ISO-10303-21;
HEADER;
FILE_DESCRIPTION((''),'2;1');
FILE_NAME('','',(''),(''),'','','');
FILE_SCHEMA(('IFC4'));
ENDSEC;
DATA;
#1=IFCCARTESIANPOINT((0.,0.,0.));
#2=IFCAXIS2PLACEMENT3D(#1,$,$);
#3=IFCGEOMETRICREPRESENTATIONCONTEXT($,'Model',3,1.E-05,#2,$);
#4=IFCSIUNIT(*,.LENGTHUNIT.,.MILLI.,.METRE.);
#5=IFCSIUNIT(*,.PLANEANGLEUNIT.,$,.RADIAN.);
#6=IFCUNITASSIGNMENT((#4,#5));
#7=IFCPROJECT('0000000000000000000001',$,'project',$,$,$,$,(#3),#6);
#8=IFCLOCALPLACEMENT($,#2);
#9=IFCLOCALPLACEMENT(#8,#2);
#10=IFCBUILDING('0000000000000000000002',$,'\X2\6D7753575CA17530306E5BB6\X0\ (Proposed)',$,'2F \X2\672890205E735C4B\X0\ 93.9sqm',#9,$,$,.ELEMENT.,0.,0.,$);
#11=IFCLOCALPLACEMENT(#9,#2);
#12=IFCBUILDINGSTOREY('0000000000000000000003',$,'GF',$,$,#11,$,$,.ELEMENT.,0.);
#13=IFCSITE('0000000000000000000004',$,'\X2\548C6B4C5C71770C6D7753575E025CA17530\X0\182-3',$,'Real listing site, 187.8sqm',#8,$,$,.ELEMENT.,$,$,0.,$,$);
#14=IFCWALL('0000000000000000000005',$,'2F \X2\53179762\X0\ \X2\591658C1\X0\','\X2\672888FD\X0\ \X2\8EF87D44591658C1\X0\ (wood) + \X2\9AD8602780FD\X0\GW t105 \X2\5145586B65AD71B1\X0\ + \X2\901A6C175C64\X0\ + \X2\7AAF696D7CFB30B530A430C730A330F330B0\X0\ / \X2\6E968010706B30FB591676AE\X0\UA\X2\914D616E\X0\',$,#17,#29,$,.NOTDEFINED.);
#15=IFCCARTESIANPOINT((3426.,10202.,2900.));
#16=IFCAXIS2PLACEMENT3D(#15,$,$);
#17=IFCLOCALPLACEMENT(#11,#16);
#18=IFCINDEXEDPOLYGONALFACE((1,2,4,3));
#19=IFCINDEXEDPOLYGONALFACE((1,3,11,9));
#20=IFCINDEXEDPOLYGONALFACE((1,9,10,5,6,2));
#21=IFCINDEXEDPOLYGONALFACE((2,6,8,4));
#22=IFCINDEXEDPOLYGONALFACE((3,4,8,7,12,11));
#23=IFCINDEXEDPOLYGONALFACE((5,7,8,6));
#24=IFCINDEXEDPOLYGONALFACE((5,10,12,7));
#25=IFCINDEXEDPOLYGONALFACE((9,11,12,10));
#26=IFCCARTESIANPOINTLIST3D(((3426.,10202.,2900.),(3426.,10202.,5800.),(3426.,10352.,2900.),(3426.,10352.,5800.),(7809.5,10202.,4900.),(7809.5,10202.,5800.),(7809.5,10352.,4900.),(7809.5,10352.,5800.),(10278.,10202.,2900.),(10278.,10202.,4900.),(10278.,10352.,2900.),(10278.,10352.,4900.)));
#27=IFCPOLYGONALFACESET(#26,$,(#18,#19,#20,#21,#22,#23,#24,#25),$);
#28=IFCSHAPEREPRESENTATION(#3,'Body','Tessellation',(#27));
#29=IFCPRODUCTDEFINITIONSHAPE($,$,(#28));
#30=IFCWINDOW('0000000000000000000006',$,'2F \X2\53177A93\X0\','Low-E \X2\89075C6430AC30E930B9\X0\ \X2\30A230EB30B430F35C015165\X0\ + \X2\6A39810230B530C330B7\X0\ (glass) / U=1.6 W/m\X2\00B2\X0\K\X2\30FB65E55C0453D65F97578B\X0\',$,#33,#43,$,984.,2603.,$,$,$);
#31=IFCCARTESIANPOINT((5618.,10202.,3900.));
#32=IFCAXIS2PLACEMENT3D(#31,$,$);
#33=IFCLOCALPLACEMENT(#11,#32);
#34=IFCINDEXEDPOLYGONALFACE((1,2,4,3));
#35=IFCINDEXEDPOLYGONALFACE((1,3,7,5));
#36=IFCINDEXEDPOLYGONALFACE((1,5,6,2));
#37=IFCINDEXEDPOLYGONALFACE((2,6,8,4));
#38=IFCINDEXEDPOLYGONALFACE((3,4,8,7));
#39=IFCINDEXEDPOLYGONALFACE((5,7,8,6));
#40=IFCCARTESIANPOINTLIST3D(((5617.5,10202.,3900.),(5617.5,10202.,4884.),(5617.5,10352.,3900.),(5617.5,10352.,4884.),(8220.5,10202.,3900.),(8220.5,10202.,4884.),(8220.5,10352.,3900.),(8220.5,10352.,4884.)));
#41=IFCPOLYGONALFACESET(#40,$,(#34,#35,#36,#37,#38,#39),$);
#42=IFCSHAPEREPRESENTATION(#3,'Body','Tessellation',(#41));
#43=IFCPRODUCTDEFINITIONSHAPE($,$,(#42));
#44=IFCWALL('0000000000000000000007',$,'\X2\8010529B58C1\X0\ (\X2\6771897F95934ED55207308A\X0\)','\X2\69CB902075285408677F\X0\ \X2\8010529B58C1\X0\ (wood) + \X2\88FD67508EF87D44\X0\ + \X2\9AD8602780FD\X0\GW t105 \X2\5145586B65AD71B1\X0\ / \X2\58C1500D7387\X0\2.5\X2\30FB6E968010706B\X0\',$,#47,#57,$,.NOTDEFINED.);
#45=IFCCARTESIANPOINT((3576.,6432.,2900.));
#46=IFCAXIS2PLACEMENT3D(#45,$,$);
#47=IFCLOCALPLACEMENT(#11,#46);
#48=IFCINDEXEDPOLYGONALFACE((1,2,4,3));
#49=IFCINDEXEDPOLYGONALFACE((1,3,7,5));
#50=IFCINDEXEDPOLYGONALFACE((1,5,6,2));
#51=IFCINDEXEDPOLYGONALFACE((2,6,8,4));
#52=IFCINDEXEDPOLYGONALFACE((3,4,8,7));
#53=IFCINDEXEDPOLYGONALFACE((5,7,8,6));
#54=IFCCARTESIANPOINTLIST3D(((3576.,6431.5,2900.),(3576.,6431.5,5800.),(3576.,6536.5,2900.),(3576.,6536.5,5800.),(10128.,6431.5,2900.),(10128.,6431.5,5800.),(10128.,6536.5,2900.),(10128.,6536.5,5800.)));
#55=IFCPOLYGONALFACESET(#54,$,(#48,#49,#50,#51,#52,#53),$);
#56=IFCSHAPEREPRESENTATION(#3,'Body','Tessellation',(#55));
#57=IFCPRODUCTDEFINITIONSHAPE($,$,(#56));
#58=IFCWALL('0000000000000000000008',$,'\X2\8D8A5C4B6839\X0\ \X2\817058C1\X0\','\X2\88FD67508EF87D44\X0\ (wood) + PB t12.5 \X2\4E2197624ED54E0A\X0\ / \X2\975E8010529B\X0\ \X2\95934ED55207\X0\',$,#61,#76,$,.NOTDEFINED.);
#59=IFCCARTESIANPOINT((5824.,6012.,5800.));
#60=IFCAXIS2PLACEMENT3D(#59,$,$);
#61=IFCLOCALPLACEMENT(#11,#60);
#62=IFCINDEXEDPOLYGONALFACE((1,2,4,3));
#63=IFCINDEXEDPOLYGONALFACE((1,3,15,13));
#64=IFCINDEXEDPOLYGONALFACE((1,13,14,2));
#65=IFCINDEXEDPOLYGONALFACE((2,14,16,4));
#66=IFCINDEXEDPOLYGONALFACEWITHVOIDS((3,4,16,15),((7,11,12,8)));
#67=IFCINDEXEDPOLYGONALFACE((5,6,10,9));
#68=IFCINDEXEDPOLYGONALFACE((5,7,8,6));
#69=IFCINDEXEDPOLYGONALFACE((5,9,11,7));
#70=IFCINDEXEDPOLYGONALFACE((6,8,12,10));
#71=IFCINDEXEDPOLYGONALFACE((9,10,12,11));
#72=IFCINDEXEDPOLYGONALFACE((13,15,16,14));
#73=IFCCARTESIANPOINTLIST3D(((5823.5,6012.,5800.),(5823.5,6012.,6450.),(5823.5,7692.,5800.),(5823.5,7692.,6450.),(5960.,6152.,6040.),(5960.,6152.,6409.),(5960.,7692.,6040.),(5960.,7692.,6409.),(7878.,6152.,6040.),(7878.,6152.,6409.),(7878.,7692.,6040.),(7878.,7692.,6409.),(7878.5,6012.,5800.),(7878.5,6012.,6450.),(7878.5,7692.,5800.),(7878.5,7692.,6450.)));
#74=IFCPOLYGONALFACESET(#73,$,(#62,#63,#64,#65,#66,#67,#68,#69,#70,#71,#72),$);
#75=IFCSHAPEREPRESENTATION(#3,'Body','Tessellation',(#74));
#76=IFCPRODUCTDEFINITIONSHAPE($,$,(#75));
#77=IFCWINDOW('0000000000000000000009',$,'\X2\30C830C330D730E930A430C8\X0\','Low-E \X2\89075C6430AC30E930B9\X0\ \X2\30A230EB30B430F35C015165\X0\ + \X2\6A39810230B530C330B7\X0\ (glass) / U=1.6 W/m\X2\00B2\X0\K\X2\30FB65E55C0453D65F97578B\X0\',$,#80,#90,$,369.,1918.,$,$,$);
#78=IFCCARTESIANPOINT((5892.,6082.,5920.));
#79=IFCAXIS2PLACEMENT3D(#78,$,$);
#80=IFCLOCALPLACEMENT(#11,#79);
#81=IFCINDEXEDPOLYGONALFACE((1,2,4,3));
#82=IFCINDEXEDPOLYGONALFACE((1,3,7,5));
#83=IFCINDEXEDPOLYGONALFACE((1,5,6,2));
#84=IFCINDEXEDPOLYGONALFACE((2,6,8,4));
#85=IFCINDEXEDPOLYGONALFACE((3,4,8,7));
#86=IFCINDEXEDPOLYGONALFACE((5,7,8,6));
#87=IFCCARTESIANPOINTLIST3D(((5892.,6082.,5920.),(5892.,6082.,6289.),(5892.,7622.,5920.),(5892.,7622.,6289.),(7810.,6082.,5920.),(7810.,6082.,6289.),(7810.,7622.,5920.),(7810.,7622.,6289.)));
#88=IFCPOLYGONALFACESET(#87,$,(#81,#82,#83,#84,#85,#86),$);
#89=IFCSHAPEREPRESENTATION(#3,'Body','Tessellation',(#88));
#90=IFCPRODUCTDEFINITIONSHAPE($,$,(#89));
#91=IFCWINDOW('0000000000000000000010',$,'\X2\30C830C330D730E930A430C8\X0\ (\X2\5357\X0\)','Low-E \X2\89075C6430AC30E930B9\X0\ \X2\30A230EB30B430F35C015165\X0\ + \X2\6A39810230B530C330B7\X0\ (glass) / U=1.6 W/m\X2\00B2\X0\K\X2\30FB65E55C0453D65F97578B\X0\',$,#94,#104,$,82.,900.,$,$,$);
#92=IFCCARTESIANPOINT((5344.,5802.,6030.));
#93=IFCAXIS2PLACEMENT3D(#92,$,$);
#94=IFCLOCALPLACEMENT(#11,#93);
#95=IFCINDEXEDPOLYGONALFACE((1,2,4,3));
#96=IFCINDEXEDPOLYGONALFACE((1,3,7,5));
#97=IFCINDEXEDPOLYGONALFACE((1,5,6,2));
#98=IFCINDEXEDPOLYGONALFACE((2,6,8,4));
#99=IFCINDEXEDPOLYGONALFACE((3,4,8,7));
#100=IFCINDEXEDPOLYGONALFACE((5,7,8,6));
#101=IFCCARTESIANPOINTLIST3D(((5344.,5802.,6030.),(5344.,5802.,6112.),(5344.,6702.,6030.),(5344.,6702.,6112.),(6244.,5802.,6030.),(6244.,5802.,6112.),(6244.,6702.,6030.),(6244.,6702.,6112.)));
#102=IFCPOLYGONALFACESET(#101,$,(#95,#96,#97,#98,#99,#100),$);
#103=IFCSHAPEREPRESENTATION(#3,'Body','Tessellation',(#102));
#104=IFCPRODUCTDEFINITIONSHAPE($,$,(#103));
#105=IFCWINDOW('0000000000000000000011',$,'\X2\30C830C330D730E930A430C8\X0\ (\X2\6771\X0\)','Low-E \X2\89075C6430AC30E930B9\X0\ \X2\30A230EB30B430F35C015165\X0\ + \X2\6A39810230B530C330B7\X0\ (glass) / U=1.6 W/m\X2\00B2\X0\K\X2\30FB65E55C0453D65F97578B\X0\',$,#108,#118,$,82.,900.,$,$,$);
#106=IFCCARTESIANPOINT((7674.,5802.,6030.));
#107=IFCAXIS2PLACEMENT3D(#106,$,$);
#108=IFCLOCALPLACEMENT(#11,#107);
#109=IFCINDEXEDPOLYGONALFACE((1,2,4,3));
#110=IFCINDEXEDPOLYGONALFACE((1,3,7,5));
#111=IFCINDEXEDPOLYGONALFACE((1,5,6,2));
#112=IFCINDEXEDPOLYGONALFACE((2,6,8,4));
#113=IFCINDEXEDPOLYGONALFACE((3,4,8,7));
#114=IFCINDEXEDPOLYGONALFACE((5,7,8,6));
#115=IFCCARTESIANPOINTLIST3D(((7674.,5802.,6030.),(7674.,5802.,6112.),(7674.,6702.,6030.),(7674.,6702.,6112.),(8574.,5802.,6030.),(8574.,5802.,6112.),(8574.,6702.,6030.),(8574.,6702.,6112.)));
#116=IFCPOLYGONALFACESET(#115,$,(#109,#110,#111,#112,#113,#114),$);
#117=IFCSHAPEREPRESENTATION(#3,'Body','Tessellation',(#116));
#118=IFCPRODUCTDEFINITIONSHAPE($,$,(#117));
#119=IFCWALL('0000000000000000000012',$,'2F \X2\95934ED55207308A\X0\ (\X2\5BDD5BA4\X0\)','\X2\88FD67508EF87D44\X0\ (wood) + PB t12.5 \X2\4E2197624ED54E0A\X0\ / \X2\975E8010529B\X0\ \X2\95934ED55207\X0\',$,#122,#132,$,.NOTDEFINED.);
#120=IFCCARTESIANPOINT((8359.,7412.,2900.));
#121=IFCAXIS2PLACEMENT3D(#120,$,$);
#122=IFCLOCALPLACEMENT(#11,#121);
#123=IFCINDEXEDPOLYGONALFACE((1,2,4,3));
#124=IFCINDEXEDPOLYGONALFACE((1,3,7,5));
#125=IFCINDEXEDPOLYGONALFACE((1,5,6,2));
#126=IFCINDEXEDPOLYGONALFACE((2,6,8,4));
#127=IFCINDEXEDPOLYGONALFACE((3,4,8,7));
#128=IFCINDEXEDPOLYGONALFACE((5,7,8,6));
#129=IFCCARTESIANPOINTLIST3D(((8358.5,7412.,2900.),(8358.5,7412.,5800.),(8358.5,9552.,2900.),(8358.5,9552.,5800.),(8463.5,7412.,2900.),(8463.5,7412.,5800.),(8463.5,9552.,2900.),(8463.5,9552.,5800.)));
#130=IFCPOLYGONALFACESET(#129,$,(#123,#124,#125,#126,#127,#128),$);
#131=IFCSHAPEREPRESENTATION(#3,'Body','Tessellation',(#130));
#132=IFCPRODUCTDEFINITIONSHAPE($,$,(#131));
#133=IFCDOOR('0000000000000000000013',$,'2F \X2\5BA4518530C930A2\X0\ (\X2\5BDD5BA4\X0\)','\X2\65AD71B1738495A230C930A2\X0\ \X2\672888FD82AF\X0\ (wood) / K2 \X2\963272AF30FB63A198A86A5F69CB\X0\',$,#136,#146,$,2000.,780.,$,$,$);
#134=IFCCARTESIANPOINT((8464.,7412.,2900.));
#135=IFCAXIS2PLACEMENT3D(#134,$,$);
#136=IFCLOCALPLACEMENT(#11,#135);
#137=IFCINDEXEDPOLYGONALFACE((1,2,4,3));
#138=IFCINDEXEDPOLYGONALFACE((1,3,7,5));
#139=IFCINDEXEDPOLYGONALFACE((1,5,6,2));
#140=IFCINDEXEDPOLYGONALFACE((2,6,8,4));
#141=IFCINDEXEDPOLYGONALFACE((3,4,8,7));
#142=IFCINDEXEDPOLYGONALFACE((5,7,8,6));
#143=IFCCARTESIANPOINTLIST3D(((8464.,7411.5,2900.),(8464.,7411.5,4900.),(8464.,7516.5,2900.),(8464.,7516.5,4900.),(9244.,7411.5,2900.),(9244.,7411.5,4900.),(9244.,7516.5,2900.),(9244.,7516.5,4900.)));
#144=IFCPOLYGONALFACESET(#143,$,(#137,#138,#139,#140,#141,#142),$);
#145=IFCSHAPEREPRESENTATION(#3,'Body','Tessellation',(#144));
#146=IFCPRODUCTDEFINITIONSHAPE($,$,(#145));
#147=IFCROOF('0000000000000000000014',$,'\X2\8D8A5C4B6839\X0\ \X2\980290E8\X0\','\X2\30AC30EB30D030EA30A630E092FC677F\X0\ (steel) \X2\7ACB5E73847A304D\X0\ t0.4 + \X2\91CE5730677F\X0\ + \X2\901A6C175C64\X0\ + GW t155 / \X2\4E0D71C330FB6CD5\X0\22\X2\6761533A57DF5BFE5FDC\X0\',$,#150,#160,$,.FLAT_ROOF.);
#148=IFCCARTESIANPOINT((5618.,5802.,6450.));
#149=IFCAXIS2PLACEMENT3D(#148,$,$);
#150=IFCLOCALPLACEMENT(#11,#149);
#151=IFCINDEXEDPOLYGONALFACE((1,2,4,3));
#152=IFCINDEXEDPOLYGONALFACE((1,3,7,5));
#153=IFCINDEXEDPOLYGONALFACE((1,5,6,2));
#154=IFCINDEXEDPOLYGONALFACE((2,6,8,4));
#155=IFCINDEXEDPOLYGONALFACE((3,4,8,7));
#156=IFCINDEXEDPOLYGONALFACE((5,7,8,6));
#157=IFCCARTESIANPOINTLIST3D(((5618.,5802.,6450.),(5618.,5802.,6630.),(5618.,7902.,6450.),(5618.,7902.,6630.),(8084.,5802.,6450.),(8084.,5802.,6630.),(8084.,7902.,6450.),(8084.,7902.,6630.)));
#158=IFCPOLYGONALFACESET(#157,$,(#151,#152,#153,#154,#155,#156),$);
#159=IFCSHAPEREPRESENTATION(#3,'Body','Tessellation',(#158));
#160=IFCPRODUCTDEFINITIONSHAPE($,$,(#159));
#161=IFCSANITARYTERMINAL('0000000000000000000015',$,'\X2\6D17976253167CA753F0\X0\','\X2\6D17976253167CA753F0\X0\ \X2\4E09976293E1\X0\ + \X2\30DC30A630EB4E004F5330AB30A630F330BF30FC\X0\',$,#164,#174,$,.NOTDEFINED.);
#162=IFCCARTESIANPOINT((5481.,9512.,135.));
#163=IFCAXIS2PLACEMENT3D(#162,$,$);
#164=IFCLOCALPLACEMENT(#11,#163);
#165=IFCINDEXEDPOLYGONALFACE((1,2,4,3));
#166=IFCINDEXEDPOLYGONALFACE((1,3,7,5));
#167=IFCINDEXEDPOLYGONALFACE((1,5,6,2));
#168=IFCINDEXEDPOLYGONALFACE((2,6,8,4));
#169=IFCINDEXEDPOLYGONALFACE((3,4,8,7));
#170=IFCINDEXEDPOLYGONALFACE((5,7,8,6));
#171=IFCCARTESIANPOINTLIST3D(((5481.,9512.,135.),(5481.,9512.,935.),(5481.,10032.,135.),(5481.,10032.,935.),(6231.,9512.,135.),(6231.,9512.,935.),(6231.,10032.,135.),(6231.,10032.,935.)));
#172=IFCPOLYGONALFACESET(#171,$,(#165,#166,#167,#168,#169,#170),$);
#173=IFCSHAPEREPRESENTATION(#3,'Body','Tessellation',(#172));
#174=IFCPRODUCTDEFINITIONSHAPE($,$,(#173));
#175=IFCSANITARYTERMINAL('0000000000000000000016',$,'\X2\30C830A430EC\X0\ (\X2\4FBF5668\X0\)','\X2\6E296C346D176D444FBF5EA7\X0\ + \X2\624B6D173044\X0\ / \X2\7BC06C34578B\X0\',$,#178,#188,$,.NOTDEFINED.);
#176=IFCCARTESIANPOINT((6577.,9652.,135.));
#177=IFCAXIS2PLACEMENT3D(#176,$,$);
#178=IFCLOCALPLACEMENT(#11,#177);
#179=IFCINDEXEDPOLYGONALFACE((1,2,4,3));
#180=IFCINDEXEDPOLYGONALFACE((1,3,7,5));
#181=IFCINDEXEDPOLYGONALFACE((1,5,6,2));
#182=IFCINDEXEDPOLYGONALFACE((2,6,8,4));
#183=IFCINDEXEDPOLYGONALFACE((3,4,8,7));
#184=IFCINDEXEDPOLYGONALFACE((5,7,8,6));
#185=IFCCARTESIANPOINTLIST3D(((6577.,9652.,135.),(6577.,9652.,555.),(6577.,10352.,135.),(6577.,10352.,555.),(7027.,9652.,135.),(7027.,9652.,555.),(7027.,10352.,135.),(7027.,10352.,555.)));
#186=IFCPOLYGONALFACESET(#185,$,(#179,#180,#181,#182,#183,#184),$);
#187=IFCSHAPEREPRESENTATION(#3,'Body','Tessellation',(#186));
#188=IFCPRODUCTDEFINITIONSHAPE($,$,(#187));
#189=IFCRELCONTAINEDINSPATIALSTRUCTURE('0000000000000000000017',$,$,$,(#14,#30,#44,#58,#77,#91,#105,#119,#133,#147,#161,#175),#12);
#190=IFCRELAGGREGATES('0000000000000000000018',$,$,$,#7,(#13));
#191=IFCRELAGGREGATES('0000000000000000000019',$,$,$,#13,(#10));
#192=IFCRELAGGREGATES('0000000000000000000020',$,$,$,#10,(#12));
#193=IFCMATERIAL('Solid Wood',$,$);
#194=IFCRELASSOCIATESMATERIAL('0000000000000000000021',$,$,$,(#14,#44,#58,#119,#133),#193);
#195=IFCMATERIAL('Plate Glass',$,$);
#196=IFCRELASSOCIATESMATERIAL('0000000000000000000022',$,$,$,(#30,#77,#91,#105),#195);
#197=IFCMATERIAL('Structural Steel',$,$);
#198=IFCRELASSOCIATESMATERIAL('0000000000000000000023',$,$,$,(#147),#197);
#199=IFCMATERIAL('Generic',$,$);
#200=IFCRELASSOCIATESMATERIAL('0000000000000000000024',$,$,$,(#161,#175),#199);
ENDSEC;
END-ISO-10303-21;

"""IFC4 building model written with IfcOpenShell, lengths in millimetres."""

from ifc_helpers import new_model, si_unit, frame, frame_2d, origin, place, context, project, spatial, rectangle, extrude, material, element, fill, save


model = new_model("IFC4")

# Units and contexts
model_context = context("Model", 3, precision=1e-05, world=origin())
ifc_project = project(units=[si_unit("LENGTHUNIT", "METRE", prefix="MILLI"), si_unit("PLANEANGLEUNIT", "RADIAN")], contexts=[model_context])

# Site, building, storey
site_placement = place(None, origin())
site = spatial("IfcSite", under=ifc_project, at=site_placement, Name="和歌山県海南市岡田182-3", ObjectType="Real listing site, 187.8sqm", CompositionType="ELEMENT", RefElevation=0.0)
building_placement = place(site_placement, origin())
building = spatial("IfcBuilding", under=site, at=building_placement, Name="海南岡田の家 (Proposed)", ObjectType="2F 木造平屋 93.9sqm", CompositionType="ELEMENT", ElevationOfRefHeight=0.0, ElevationOfTerrain=0.0)
storey_placement = place(building_placement, origin())
storey = spatial("IfcBuildingStorey", under=building, at=storey_placement, Name="GF", CompositionType="ELEMENT", Elevation=0.0)

# Wall, opening, window
ifc_material_1 = material(Name="Solid Wood")
wall_1_placement = place(storey_placement, frame((3426.0, 10202.0, 2900.0)))
wall_1 = element("IfcWall", 1, at=wall_1_placement, inside=storey, material=ifc_material_1, Name="2F 北面 外壁", Description="木製 軸組外壁 (wood) + 高性能GW t105 充填断熱 + 通気層 + 窯業系サイディング / 準耐火・外皮UA配慮", PredefinedType="NOTDEFINED", context=model_context, shape_type="SweptSolid", body=[
    extrude(rectangle(XDim=6852.0, YDim=150.0, at=frame_2d((3426.0, 75.0))), frame((3426.0, 10202.0, 2900.0)), (0.0, 0.0, 1.0), 2900.0),
])
opening_1_placement = place(storey_placement, frame((5618.0, 10202.0, 3900.0)))
opening_1 = element("IfcOpeningElement", 2, at=opening_1_placement, cuts=wall_1, PredefinedType="NOTDEFINED", context=model_context, shape_type="SweptSolid", body=[
    extrude(rectangle(XDim=2603.0, YDim=150.0, at=frame_2d((1301.0, 75.0))), frame((5618.0, 10202.0, 3900.0)), (0.0, 0.0, 1.0), 984.0),
])
ifc_material_2 = material(Name="Plate Glass")
window_1_placement = place(storey_placement, frame((5618.0, 10202.0, 3900.0)))
window_1 = element("IfcWindow", 3, at=window_1_placement, inside=storey, material=ifc_material_2, Name="2F 北窓", Description="Low-E 複層ガラス アルゴン封入 + 樹脂サッシ (glass) / U=1.6 W/m²K・日射取得型", OverallHeight=984.0, OverallWidth=2603.0, context=model_context, shape_type="SweptSolid", body=[
    extrude(rectangle(XDim=2603.0, YDim=150.0, at=frame_2d((1301.0, 75.0))), frame((5618.0, 10202.0, 3900.0)), (0.0, 0.0, 1.0), 984.0),
])
fill(opening_1, window_1)

# Wall
wall_2_placement = place(storey_placement, frame((3576.0, 6432.0, 2900.0)))
element("IfcWall", 4, at=wall_2_placement, inside=storey, material=ifc_material_1, Name="耐力壁 (東西間仕切り)", Description="構造用合板 耐力壁 (wood) + 製材軸組 + 高性能GW t105 充填断熱 / 壁倍率2.5・準耐火", PredefinedType="NOTDEFINED", context=model_context, shape_type="SweptSolid", body=[
    extrude(rectangle(XDim=6552.0, YDim=105.0, at=frame_2d((3276.0, 52.0))), frame((3576.0, 6432.0, 2900.0)), (0.0, 0.0, 1.0), 2900.0),
])

# Wall, openings, windows
wall_3_placement = place(storey_placement, frame((5824.0, 6012.0, 5800.0)))
wall_3 = element("IfcWall", 5, at=wall_3_placement, inside=storey, material=ifc_material_1, Name="越屋根 腰壁", Description="製材軸組 (wood) + PB t12.5 両面仕上 / 非耐力 間仕切", PredefinedType="NOTDEFINED", context=model_context, shape_type="SweptSolid", body=[
    extrude(rectangle(XDim=2055.0, YDim=1680.0, at=frame_2d((1027.0, 840.0))), frame((5824.0, 6012.0, 5800.0)), (0.0, 0.0, 1.0), 650.0),
])
opening_2_placement = place(storey_placement, frame((5892.0, 6082.0, 5920.0)))
opening_2 = element("IfcOpeningElement", 6, at=opening_2_placement, cuts=wall_3, PredefinedType="NOTDEFINED", context=model_context, shape_type="SweptSolid", body=[
    extrude(rectangle(XDim=1918.0, YDim=1540.0, at=frame_2d((959.0, 770.0))), frame((5892.0, 6082.0, 5920.0)), (0.0, 0.0, 1.0), 369.0),
])
opening_3_placement = place(storey_placement, frame((5344.0, 5802.0, 6030.0)))
opening_3 = element("IfcOpeningElement", 7, at=opening_3_placement, cuts=wall_3, PredefinedType="NOTDEFINED", context=model_context, shape_type="SweptSolid", body=[
    extrude(rectangle(XDim=900.0, YDim=900.0, at=frame_2d((450.0, 450.0))), frame((5344.0, 5802.0, 6030.0)), (0.0, 0.0, 1.0), 82.0),
])
opening_4_placement = place(storey_placement, frame((7674.0, 5802.0, 6030.0)))
opening_4 = element("IfcOpeningElement", 8, at=opening_4_placement, cuts=wall_3, PredefinedType="NOTDEFINED", context=model_context, shape_type="SweptSolid", body=[
    extrude(rectangle(XDim=900.0, YDim=900.0, at=frame_2d((450.0, 450.0))), frame((7674.0, 5802.0, 6030.0)), (0.0, 0.0, 1.0), 82.0),
])
window_2_placement = place(storey_placement, frame((5892.0, 6082.0, 5920.0)))
window_2 = element("IfcWindow", 9, at=window_2_placement, inside=storey, material=ifc_material_2, Name="トップライト", Description="Low-E 複層ガラス アルゴン封入 + 樹脂サッシ (glass) / U=1.6 W/m²K・日射取得型", OverallHeight=369.0, OverallWidth=1918.0, context=model_context, shape_type="SweptSolid", body=[
    extrude(rectangle(XDim=1918.0, YDim=1540.0, at=frame_2d((959.0, 770.0))), frame((5892.0, 6082.0, 5920.0)), (0.0, 0.0, 1.0), 369.0),
])
fill(opening_2, window_2)
window_3_placement = place(storey_placement, frame((5344.0, 5802.0, 6030.0)))
window_3 = element("IfcWindow", 10, at=window_3_placement, inside=storey, material=ifc_material_2, Name="トップライト (南)", Description="Low-E 複層ガラス アルゴン封入 + 樹脂サッシ (glass) / U=1.6 W/m²K・日射取得型", OverallHeight=82.0, OverallWidth=900.0, context=model_context, shape_type="SweptSolid", body=[
    extrude(rectangle(XDim=900.0, YDim=900.0, at=frame_2d((450.0, 450.0))), frame((5344.0, 5802.0, 6030.0)), (0.0, 0.0, 1.0), 82.0),
])
fill(opening_3, window_3)
window_4_placement = place(storey_placement, frame((7674.0, 5802.0, 6030.0)))
window_4 = element("IfcWindow", 11, at=window_4_placement, inside=storey, material=ifc_material_2, Name="トップライト (東)", Description="Low-E 複層ガラス アルゴン封入 + 樹脂サッシ (glass) / U=1.6 W/m²K・日射取得型", OverallHeight=82.0, OverallWidth=900.0, context=model_context, shape_type="SweptSolid", body=[
    extrude(rectangle(XDim=900.0, YDim=900.0, at=frame_2d((450.0, 450.0))), frame((7674.0, 5802.0, 6030.0)), (0.0, 0.0, 1.0), 82.0),
])
fill(opening_4, window_4)

# Wall
wall_4_placement = place(storey_placement, frame((8359.0, 7412.0, 2900.0)))
element("IfcWall", 12, at=wall_4_placement, inside=storey, material=ifc_material_1, Name="2F 間仕切り (寝室)", Description="製材軸組 (wood) + PB t12.5 両面仕上 / 非耐力 間仕切", PredefinedType="NOTDEFINED", context=model_context, shape_type="SweptSolid", body=[
    extrude(rectangle(XDim=105.0, YDim=2140.0, at=frame_2d((52.0, 1070.0))), frame((8359.0, 7412.0, 2900.0)), (0.0, 0.0, 1.0), 2900.0),
])

# Door
door_placement = place(storey_placement, frame((8464.0, 7412.0, 2900.0)))
element("IfcDoor", 13, at=door_placement, inside=storey, material=ifc_material_1, Name="2F 室内ドア (寝室)", Description="断熱玄関ドア 木製芯 (wood) / K2 防犯・採風機構", OverallHeight=2000.0, OverallWidth=780.0, context=model_context, shape_type="SweptSolid", body=[
    extrude(rectangle(XDim=780.0, YDim=105.0, at=frame_2d((390.0, 52.0))), frame((8464.0, 7412.0, 2900.0)), (0.0, 0.0, 1.0), 2000.0),
])

# Roof
ifc_material_3 = material(Name="Structural Steel")
roof_placement = place(storey_placement, frame((5618.0, 5802.0, 6450.0)))
element("IfcRoof", 14, at=roof_placement, inside=storey, material=ifc_material_3, Name="越屋根 頂部", Description="ガルバリウム鋼板 (steel) 立平葺き t0.4 + 野地板 + 通気層 + GW t155 / 不燃・法22条区域対応", PredefinedType="FLAT_ROOF", context=model_context, shape_type="SweptSolid", body=[
    extrude(rectangle(XDim=2466.0, YDim=2100.0, at=frame_2d((1233.0, 1050.0))), frame((5618.0, 5802.0, 6450.0)), (0.0, 0.0, 1.0), 180.0),
])

# Sanitary terminals
ifc_material_4 = material(Name="Generic")
sanitary_terminal_1_placement = place(storey_placement, frame((5481.0, 9512.0, 135.0)))
element("IfcSanitaryTerminal", 15, at=sanitary_terminal_1_placement, inside=storey, material=ifc_material_4, Name="洗面化粧台", Description="洗面化粧台 三面鏡 + ボウル一体カウンター", PredefinedType="NOTDEFINED", context=model_context, shape_type="SweptSolid", body=[
    extrude(rectangle(XDim=750.0, YDim=520.0, at=frame_2d((375.0, 260.0))), frame((5481.0, 9512.0, 135.0)), (0.0, 0.0, 1.0), 800.0),
])
sanitary_terminal_2_placement = place(storey_placement, frame((6577.0, 9652.0, 135.0)))
element("IfcSanitaryTerminal", 16, at=sanitary_terminal_2_placement, inside=storey, material=ifc_material_4, Name="トイレ (便器)", Description="温水洗浄便座 + 手洗い / 節水型", PredefinedType="NOTDEFINED", context=model_context, shape_type="SweptSolid", body=[
    extrude(rectangle(XDim=450.0, YDim=700.0, at=frame_2d((225.0, 350.0))), frame((6577.0, 9652.0, 135.0)), (0.0, 0.0, 1.0), 420.0),
])

save(model, "model.ifc")
